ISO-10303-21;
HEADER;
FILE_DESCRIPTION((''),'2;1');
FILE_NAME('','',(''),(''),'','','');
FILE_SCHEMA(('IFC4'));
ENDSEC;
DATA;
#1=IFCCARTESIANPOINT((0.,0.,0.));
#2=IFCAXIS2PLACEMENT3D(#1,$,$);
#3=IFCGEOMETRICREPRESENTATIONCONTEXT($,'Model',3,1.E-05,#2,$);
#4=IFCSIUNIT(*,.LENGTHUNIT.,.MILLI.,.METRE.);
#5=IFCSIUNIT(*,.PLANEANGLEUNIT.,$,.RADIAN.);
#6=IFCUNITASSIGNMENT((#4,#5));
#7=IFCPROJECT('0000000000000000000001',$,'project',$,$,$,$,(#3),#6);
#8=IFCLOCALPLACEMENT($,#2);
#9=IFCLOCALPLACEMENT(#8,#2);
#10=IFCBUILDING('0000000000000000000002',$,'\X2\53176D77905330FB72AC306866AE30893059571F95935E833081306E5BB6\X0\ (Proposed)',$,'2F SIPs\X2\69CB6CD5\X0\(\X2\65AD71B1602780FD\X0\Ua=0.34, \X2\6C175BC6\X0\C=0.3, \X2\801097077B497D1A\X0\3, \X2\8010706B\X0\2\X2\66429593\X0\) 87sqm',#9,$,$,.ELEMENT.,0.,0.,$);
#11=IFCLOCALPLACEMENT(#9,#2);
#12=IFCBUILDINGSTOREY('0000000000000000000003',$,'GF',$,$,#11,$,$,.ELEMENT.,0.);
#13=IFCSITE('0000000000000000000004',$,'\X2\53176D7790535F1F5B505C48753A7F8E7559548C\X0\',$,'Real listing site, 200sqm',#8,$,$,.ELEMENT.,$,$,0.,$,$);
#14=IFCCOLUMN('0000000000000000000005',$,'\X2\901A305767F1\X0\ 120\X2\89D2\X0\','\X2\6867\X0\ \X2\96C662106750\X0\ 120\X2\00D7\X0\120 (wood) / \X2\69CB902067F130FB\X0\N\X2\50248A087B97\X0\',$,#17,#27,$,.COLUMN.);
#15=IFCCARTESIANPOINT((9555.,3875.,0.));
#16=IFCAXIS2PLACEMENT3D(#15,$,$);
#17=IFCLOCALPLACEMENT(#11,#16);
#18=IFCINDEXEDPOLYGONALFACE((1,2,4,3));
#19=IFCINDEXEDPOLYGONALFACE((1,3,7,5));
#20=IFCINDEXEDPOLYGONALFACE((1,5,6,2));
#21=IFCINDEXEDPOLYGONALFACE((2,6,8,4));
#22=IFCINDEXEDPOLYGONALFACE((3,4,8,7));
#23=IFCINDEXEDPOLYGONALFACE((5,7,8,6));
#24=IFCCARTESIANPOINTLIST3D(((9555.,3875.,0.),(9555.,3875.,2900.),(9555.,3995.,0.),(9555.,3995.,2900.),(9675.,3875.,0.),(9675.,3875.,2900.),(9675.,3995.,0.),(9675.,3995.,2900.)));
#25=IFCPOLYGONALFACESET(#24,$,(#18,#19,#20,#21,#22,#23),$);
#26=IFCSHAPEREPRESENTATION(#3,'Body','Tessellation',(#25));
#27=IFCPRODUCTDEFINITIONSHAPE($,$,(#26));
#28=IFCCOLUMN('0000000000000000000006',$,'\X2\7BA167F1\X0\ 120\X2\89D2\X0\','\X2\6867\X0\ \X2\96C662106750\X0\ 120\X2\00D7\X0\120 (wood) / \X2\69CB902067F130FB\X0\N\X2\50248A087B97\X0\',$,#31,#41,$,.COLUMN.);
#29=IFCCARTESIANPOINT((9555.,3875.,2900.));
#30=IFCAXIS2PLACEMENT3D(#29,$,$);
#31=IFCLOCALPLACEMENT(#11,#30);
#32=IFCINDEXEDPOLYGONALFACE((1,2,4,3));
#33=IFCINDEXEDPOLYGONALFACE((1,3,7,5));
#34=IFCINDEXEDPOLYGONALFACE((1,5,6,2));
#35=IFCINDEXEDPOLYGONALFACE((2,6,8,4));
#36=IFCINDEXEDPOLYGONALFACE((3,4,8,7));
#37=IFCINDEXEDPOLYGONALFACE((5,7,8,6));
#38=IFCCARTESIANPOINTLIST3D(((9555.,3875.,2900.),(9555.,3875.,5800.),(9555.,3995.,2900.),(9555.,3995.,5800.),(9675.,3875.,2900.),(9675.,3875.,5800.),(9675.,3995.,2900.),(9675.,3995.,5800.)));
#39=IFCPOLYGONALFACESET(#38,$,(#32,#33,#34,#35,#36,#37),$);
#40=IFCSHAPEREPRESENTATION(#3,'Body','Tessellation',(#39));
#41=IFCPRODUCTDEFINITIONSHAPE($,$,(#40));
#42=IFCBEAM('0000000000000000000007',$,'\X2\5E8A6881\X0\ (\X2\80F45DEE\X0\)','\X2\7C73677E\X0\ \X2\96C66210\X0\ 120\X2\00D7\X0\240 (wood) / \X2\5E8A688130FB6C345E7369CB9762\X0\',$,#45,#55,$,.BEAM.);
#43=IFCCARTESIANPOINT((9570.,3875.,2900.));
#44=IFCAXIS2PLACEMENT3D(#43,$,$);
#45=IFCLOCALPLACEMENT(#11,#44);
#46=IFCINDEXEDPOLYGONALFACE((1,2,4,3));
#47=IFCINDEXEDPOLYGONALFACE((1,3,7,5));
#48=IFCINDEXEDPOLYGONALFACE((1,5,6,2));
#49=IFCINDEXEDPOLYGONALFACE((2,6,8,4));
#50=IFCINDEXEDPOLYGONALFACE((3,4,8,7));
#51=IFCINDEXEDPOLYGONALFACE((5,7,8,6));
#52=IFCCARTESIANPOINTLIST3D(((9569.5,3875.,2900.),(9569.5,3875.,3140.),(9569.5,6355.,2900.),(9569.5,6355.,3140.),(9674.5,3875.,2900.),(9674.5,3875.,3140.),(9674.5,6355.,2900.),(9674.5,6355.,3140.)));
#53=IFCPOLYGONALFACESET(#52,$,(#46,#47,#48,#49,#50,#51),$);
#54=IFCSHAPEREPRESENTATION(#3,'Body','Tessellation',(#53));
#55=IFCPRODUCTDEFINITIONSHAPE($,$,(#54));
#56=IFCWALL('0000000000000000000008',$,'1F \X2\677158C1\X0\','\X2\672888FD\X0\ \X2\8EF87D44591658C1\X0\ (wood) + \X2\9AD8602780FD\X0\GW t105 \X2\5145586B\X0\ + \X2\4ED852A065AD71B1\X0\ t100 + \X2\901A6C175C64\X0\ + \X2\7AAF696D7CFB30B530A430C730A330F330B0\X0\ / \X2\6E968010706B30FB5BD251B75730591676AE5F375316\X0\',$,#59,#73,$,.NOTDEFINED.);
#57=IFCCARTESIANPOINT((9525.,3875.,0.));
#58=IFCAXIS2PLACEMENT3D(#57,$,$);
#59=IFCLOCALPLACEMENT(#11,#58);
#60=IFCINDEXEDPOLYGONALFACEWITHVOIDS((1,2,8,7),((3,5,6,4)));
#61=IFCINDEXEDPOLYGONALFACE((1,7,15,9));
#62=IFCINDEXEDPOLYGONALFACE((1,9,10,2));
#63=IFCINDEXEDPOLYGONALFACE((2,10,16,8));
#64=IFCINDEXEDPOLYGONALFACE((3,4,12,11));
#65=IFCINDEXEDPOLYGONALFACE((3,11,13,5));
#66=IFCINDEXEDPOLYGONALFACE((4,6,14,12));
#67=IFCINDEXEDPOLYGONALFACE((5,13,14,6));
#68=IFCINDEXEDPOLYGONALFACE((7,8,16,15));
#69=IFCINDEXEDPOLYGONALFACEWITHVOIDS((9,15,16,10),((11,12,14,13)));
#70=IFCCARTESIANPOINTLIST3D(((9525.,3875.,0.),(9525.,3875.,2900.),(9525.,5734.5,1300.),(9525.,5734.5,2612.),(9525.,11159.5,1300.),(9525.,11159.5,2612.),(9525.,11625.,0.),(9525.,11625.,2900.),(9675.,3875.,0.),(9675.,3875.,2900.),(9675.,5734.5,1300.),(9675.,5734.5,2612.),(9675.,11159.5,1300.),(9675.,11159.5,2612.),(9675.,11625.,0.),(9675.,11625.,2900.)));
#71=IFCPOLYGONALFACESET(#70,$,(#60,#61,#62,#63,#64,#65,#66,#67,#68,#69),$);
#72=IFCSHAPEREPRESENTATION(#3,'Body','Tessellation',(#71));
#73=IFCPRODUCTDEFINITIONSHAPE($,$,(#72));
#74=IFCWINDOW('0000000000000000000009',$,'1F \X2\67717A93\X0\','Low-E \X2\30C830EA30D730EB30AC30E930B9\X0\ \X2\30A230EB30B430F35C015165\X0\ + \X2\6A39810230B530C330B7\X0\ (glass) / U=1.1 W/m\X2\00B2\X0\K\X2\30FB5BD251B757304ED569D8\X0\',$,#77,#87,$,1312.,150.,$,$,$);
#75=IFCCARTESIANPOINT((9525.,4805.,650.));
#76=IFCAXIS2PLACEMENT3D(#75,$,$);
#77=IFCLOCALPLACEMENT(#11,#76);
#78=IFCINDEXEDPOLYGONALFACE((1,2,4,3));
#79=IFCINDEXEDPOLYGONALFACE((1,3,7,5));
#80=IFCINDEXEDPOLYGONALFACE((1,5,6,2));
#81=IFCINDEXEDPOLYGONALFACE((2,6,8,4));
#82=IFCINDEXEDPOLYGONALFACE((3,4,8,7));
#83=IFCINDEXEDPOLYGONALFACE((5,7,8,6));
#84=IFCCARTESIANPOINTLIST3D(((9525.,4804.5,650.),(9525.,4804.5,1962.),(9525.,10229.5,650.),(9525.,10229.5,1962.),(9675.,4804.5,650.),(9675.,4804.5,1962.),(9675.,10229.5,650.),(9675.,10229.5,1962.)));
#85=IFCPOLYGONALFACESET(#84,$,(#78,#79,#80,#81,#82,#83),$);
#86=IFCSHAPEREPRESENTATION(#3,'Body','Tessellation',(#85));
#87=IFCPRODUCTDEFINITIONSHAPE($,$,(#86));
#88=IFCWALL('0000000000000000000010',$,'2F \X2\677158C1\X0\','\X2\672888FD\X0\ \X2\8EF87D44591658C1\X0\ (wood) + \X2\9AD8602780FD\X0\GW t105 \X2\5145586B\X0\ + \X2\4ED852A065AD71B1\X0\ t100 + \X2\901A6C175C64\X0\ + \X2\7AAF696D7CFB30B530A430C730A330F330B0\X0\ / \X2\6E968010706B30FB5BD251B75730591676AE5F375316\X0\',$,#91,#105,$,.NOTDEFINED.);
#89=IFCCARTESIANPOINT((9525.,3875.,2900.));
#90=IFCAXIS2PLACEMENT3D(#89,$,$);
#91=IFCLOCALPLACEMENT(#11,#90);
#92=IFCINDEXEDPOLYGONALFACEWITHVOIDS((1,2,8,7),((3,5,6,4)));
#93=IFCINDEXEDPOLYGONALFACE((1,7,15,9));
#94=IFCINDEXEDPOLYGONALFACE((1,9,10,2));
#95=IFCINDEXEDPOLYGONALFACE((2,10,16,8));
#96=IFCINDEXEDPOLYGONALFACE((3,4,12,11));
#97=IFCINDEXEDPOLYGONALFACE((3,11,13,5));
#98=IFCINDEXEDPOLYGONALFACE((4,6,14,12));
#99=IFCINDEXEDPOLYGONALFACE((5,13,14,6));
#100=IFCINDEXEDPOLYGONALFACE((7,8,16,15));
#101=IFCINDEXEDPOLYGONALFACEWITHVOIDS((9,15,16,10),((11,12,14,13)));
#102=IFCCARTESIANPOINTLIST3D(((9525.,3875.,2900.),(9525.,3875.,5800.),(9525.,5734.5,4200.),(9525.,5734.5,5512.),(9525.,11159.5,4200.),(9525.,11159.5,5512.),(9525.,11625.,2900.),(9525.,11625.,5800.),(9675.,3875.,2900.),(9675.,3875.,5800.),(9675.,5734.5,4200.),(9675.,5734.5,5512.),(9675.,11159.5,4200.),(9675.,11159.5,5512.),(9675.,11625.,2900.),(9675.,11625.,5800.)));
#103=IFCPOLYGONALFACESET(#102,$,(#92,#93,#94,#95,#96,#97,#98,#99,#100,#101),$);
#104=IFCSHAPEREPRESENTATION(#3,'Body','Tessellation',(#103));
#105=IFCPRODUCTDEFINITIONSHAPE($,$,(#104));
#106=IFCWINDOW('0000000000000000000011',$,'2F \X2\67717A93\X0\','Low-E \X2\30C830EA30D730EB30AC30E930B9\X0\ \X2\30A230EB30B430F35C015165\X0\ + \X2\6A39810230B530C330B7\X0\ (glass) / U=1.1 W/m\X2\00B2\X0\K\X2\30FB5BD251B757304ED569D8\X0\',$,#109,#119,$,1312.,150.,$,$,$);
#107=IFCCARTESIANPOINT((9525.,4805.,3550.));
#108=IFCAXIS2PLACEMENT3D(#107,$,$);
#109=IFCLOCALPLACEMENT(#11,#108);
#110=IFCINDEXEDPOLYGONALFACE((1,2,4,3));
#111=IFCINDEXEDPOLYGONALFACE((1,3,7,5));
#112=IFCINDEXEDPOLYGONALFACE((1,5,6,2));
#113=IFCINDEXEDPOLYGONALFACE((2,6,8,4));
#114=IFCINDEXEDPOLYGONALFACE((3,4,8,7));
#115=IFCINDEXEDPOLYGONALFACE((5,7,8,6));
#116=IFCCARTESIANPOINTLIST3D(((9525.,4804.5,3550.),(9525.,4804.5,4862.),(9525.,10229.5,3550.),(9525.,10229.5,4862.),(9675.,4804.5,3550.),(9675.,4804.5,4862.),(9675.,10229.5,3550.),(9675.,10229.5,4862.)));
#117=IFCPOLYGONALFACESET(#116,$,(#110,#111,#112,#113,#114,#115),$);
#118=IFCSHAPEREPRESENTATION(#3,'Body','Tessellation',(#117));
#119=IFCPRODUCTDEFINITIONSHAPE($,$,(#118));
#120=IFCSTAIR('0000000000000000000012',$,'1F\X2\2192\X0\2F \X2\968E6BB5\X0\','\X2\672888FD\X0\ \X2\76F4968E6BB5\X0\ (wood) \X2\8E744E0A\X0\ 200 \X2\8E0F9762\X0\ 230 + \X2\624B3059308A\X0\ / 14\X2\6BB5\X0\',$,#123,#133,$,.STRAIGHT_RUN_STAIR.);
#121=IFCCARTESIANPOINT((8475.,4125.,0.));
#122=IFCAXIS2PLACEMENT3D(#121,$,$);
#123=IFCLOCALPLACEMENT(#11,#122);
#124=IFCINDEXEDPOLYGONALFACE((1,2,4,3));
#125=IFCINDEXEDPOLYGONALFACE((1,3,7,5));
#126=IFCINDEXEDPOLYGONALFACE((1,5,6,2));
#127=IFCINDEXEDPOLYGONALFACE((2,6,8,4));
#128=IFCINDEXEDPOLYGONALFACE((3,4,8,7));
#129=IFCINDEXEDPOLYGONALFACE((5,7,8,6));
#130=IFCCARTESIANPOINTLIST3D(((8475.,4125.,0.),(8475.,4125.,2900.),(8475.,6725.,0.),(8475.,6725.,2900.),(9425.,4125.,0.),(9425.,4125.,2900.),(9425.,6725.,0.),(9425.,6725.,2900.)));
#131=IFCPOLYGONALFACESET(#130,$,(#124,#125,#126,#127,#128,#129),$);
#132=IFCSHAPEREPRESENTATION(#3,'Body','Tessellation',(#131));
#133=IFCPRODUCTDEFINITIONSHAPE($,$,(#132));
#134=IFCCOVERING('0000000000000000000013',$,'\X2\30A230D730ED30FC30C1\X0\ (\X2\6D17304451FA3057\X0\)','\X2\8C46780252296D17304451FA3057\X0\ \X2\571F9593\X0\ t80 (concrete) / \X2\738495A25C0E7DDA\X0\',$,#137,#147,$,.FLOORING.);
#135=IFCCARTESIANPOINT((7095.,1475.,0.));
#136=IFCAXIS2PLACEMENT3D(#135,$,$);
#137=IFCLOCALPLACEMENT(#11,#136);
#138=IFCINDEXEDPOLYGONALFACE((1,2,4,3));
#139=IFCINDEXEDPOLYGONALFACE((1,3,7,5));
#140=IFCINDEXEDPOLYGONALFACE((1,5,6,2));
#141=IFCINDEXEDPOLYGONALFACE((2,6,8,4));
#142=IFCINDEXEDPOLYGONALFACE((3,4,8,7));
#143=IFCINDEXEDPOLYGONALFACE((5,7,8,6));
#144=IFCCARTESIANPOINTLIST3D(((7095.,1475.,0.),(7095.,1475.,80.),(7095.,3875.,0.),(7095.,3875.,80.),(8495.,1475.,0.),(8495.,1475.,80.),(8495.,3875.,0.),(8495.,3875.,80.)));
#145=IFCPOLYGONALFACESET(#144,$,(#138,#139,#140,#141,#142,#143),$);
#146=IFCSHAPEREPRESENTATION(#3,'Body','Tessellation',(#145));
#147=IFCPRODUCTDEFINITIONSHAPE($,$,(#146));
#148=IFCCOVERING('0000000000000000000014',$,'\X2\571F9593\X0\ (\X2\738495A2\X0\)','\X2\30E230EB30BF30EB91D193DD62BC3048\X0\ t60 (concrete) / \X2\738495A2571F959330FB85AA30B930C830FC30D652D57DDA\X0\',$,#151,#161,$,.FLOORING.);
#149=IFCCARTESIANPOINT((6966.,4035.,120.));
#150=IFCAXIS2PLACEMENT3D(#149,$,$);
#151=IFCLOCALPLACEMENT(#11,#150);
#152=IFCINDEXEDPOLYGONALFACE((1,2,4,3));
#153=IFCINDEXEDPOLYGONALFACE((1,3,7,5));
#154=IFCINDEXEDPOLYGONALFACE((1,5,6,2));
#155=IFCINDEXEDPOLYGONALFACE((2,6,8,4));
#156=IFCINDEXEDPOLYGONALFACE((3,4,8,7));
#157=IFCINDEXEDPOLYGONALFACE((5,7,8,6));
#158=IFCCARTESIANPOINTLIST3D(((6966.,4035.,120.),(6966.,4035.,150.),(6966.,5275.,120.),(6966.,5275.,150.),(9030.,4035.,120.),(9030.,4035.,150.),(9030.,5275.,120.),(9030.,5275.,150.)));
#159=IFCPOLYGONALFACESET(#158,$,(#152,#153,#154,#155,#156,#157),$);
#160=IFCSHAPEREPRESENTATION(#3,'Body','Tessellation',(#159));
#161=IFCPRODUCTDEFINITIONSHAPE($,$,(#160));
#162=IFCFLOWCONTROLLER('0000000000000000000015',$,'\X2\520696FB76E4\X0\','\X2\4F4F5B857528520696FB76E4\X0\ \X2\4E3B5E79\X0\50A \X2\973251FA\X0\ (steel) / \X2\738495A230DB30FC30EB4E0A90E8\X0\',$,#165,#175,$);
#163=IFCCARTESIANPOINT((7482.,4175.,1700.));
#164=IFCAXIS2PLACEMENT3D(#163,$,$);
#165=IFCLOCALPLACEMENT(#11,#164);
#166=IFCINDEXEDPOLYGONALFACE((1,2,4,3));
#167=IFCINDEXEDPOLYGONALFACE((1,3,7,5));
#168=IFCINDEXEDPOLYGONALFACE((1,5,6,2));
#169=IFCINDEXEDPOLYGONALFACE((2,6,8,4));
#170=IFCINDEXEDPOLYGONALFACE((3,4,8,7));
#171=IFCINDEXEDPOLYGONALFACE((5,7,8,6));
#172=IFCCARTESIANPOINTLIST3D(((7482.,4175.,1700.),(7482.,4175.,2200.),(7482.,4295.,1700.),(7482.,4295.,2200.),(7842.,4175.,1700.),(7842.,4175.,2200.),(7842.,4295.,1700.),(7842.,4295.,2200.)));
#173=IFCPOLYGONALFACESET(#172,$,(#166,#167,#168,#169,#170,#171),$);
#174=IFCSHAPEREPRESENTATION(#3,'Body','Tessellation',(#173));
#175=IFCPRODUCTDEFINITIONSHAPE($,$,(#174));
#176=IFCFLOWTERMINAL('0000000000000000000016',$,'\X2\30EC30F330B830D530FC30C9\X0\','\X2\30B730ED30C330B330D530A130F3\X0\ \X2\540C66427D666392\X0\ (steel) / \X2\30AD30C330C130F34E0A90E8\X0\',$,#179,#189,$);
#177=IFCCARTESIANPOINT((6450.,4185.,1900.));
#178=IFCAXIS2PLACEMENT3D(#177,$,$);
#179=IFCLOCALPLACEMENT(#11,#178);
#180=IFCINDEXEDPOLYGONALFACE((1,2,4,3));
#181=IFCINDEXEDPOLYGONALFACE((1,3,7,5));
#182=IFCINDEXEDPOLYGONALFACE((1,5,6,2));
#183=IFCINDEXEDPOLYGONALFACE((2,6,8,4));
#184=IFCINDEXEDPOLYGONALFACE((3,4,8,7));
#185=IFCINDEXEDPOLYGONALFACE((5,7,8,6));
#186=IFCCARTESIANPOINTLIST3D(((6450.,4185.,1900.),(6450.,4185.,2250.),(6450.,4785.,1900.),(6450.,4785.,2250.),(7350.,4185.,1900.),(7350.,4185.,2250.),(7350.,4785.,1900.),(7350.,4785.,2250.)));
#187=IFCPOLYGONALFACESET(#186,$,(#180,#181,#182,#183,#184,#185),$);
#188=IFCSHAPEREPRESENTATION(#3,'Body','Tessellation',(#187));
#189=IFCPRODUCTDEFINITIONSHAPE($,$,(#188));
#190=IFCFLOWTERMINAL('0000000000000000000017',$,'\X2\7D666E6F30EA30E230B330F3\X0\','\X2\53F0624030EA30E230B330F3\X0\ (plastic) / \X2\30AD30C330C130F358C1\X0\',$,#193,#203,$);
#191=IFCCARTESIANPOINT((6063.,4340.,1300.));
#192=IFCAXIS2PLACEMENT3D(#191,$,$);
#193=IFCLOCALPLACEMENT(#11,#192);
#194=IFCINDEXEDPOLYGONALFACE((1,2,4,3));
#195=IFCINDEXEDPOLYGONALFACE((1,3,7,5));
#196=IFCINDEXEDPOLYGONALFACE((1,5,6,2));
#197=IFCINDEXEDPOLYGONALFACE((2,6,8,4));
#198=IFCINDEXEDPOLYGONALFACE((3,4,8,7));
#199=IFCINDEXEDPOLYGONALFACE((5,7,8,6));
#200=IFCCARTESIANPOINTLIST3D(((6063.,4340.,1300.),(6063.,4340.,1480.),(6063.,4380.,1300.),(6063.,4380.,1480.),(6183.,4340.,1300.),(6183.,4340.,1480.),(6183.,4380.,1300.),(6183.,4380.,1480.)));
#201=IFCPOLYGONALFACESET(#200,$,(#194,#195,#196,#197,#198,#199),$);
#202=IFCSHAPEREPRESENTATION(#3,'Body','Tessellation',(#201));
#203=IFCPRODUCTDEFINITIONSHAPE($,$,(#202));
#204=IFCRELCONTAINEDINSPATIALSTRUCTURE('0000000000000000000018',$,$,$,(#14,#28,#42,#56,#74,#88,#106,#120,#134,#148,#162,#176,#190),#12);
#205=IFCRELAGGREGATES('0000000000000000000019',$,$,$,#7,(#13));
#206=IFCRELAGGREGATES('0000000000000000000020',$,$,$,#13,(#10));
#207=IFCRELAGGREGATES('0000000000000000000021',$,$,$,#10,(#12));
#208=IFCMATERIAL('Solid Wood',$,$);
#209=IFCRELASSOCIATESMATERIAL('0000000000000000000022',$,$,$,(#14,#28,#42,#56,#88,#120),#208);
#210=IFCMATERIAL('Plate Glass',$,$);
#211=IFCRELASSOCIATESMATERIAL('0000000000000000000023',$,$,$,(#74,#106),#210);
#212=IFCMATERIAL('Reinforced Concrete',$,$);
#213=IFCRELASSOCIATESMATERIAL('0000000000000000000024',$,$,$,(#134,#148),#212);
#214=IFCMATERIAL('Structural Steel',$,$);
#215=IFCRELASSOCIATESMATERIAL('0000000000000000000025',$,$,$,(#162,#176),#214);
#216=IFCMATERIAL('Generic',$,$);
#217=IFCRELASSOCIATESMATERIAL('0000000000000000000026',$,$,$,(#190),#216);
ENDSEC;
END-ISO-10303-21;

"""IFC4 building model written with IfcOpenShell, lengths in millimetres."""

from ifc_helpers import new_model, si_unit, frame, frame_2d, origin, place, context, project, spatial, rectangle, extrude, material, element, fill, save


model = new_model("IFC4")

# Units and contexts
model_context = context("Model", 3, precision=1e-05, world=origin())
ifc_project = project(units=[si_unit("LENGTHUNIT", "METRE", prefix="MILLI"), si_unit("PLANEANGLEUNIT", "RADIAN")], contexts=[model_context])

# Site, building, storey
site_placement = place(None, origin())
site = spatial("IfcSite", under=ifc_project, at=site_placement, Name="北海道弟子屈町美留和", ObjectType="Real listing site, 200sqm", CompositionType="ELEMENT", RefElevation=0.0)
building_placement = place(site_placement, origin())
building = spatial("IfcBuilding", under=site, at=building_placement, Name="北海道・犬と暮らす土間広めの家 (Proposed)", ObjectType="2F SIPs構法(断熱性能Ua=0.34, 気密C=0.3, 耐震等級3, 耐火2時間) 87sqm", CompositionType="ELEMENT", ElevationOfRefHeight=0.0, ElevationOfTerrain=0.0)
storey_placement = place(building_placement, origin())
storey = spatial("IfcBuildingStorey", under=building, at=storey_placement, Name="GF", CompositionType="ELEMENT", Elevation=0.0)

# Columns
ifc_material_1 = material(Name="Solid Wood")
column_1_placement = place(storey_placement, frame((9555.0, 3875.0, 0.0)))
element("IfcColumn", 1, at=column_1_placement, inside=storey, material=ifc_material_1, Name="通し柱 120角", Description="桧 集成材 120×120 (wood) / 構造柱・N値計算", PredefinedType="COLUMN", context=model_context, shape_type="SweptSolid", body=[
    extrude(rectangle(XDim=120.0, YDim=120.0, at=frame_2d((60.0, 60.0))), frame((9555.0, 3875.0, 0.0)), (0.0, 0.0, 1.0), 2900.0),
])
column_2_placement = place(storey_placement, frame((9555.0, 3875.0, 2900.0)))
element("IfcColumn", 2, at=column_2_placement, inside=storey, material=ifc_material_1, Name="管柱 120角", Description="桧 集成材 120×120 (wood) / 構造柱・N値計算", PredefinedType="COLUMN", context=model_context, shape_type="SweptSolid", body=[
    extrude(rectangle(XDim=120.0, YDim=120.0, at=frame_2d((60.0, 60.0))), frame((9555.0, 3875.0, 2900.0)), (0.0, 0.0, 1.0), 2900.0),
])

# Beam
beam_1_placement = place(storey_placement, frame((9570.0, 3875.0, 2900.0)))
element("IfcBeam", 3, at=beam_1_placement, inside=storey, material=ifc_material_1, Name="床梁 (胴差)", Description="米松 集成 120×240 (wood) / 床梁・水平構面", PredefinedType="BEAM", context=model_context, shape_type="SweptSolid", body=[
    extrude(rectangle(XDim=105.0, YDim=2480.0, at=frame_2d((52.0, 1240.0))), frame((9570.0, 3875.0, 2900.0)), (0.0, 0.0, 1.0), 240.0),
])

# Wall, opening, window
wall_1_placement = place(storey_placement, frame((9525.0, 3875.0, 0.0)))
wall_1 = element("IfcWall", 4, at=wall_1_placement, inside=storey, material=ifc_material_1, Name="1F 東壁", Description="木製 軸組外壁 (wood) + 高性能GW t105 充填 + 付加断熱 t100 + 通気層 + 窯業系サイディング / 準耐火・寒冷地外皮強化", PredefinedType="NOTDEFINED", context=model_context, shape_type="SweptSolid", body=[
    extrude(rectangle(XDim=150.0, YDim=7750.0, at=frame_2d((75.0, 3875.0))), frame((9525.0, 3875.0, 0.0)), (0.0, 0.0, 1.0), 2900.0),
])
opening_1_placement = place(storey_placement, frame((9525.0, 4805.0, 650.0)))
opening_1 = element("IfcOpeningElement", 5, at=opening_1_placement, cuts=wall_1, PredefinedType="NOTDEFINED", context=model_context, shape_type="SweptSolid", body=[
    extrude(rectangle(XDim=150.0, YDim=5425.0, at=frame_2d((75.0, 2712.0))), frame((9525.0, 4805.0, 650.0)), (0.0, 0.0, 1.0), 1312.0),
])
ifc_material_2 = material(Name="Plate Glass")
window_1_placement = place(storey_placement, frame((9525.0, 4805.0, 650.0)))
window_1 = element("IfcWindow", 6, at=window_1_placement, inside=storey, material=ifc_material_2, Name="1F 東窓", Description="Low-E トリプルガラス アルゴン封入 + 樹脂サッシ (glass) / U=1.1 W/m²K・寒冷地仕様", OverallHeight=1312.0, OverallWidth=150.0, context=model_context, shape_type="SweptSolid", body=[
    extrude(rectangle(XDim=150.0, YDim=5425.0, at=frame_2d((75.0, 2712.0))), frame((9525.0, 4805.0, 650.0)), (0.0, 0.0, 1.0), 1312.0),
])
fill(opening_1, window_1)

# Wall, opening, window
wall_2_placement = place(storey_placement, frame((9525.0, 3875.0, 2900.0)))
wall_2 = element("IfcWall", 7, at=wall_2_placement, inside=storey, material=ifc_material_1, Name="2F 東壁", Description="木製 軸組外壁 (wood) + 高性能GW t105 充填 + 付加断熱 t100 + 通気層 + 窯業系サイディング / 準耐火・寒冷地外皮強化", PredefinedType="NOTDEFINED", context=model_context, shape_type="SweptSolid", body=[
    extrude(rectangle(XDim=150.0, YDim=7750.0, at=frame_2d((75.0, 3875.0))), frame((9525.0, 3875.0, 2900.0)), (0.0, 0.0, 1.0), 2900.0),
])
opening_2_placement = place(storey_placement, frame((9525.0, 4805.0, 3550.0)))
opening_2 = element("IfcOpeningElement", 8, at=opening_2_placement, cuts=wall_2, PredefinedType="NOTDEFINED", context=model_context, shape_type="SweptSolid", body=[
    extrude(rectangle(XDim=150.0, YDim=5425.0, at=frame_2d((75.0, 2712.0))), frame((9525.0, 4805.0, 3550.0)), (0.0, 0.0, 1.0), 1312.0),
])
window_2_placement = place(storey_placement, frame((9525.0, 4805.0, 3550.0)))
window_2 = element("IfcWindow", 9, at=window_2_placement, inside=storey, material=ifc_material_2, Name="2F 東窓", Description="Low-E トリプルガラス アルゴン封入 + 樹脂サッシ (glass) / U=1.1 W/m²K・寒冷地仕様", OverallHeight=1312.0, OverallWidth=150.0, context=model_context, shape_type="SweptSolid", body=[
    extrude(rectangle(XDim=150.0, YDim=5425.0, at=frame_2d((75.0, 2712.0))), frame((9525.0, 4805.0, 3550.0)), (0.0, 0.0, 1.0), 1312.0),
])
fill(opening_2, window_2)

# Stair
stair_placement = place(storey_placement, frame((8475.0, 4125.0, 0.0)))
element("IfcStair", 10, at=stair_placement, inside=storey, material=ifc_material_1, Name="1F→2F 階段", Description="木製 直階段 (wood) 蹴上 200 踏面 230 + 手すり / 14段", PredefinedType="STRAIGHT_RUN_STAIR", context=model_context, shape_type="SweptSolid", body=[
    extrude(rectangle(XDim=950.0, YDim=2600.0, at=frame_2d((475.0, 1300.0))), frame((8475.0, 4125.0, 0.0)), (0.0, 0.0, 1.0), 2900.0),
])

# Coverings
ifc_material_3 = material(Name="Reinforced Concrete")
covering_1_placement = place(storey_placement, frame((7095.0, 1475.0, 0.0)))
element("IfcCovering", 11, at=covering_1_placement, inside=storey, material=ifc_material_3, Name="アプローチ (洗い出し)", Description="豆砂利洗い出し 土間 t80 (concrete) / 玄関導線", PredefinedType="FLOORING", context=model_context, shape_type="SweptSolid", body=[
    extrude(rectangle(XDim=1400.0, YDim=2400.0, at=frame_2d((700.0, 1200.0))), frame((7095.0, 1475.0, 0.0)), (0.0, 0.0, 1.0), 80.0),
])
covering_2_placement = place(storey_placement, frame((6966.0, 4035.0, 120.0)))
element("IfcCovering", 12, at=covering_2_placement, inside=storey, material=ifc_material_3, Name="土間 (玄関)", Description="モルタル金鏝押え t60 (concrete) / 玄関土間・薪ストーブ動線", PredefinedType="FLOORING", context=model_context, shape_type="SweptSolid", body=[
    extrude(rectangle(XDim=2064.0, YDim=1240.0, at=frame_2d((1032.0, 620.0))), frame((6966.0, 4035.0, 120.0)), (0.0, 0.0, 1.0), 30.0),
])

# Flow controller
ifc_material_4 = material(Name="Structural Steel")
flow_controller_placement = place(storey_placement, frame((7482.0, 4175.0, 1700.0)))
element("IfcFlowController", 13, at=flow_controller_placement, inside=storey, material=ifc_material_4, Name="分電盤", Description="住宅用分電盤 主幹50A 露出 (steel) / 玄関ホール上部", context=model_context, shape_type="SweptSolid", body=[
    extrude(rectangle(XDim=360.0, YDim=120.0, at=frame_2d((180.0, 60.0))), frame((7482.0, 4175.0, 1700.0)), (0.0, 0.0, 1.0), 500.0),
])

# Flow terminals
flow_terminal_1_placement = place(storey_placement, frame((6450.0, 4185.0, 1900.0)))
element("IfcFlowTerminal", 14, at=flow_terminal_1_placement, inside=storey, material=ifc_material_4, Name="レンジフード", Description="シロッコファン 同時給排 (steel) / キッチン上部", context=model_context, shape_type="SweptSolid", body=[
    extrude(rectangle(XDim=900.0, YDim=600.0, at=frame_2d((450.0, 300.0))), frame((6450.0, 4185.0, 1900.0)), (0.0, 0.0, 1.0), 350.0),
])
ifc_material_5 = material(Name="Generic")
flow_terminal_2_placement = place(storey_placement, frame((6063.0, 4340.0, 1300.0)))
element("IfcFlowTerminal", 15, at=flow_terminal_2_placement, inside=storey, material=ifc_material_5, Name="給湯リモコン", Description="台所リモコン (plastic) / キッチン壁", context=model_context, shape_type="SweptSolid", body=[
    extrude(rectangle(XDim=120.0, YDim=40.0, at=frame_2d((60.0, 20.0))), frame((6063.0, 4340.0, 1300.0)), (0.0, 0.0, 1.0), 180.0),
])

save(model, "model.ifc")
